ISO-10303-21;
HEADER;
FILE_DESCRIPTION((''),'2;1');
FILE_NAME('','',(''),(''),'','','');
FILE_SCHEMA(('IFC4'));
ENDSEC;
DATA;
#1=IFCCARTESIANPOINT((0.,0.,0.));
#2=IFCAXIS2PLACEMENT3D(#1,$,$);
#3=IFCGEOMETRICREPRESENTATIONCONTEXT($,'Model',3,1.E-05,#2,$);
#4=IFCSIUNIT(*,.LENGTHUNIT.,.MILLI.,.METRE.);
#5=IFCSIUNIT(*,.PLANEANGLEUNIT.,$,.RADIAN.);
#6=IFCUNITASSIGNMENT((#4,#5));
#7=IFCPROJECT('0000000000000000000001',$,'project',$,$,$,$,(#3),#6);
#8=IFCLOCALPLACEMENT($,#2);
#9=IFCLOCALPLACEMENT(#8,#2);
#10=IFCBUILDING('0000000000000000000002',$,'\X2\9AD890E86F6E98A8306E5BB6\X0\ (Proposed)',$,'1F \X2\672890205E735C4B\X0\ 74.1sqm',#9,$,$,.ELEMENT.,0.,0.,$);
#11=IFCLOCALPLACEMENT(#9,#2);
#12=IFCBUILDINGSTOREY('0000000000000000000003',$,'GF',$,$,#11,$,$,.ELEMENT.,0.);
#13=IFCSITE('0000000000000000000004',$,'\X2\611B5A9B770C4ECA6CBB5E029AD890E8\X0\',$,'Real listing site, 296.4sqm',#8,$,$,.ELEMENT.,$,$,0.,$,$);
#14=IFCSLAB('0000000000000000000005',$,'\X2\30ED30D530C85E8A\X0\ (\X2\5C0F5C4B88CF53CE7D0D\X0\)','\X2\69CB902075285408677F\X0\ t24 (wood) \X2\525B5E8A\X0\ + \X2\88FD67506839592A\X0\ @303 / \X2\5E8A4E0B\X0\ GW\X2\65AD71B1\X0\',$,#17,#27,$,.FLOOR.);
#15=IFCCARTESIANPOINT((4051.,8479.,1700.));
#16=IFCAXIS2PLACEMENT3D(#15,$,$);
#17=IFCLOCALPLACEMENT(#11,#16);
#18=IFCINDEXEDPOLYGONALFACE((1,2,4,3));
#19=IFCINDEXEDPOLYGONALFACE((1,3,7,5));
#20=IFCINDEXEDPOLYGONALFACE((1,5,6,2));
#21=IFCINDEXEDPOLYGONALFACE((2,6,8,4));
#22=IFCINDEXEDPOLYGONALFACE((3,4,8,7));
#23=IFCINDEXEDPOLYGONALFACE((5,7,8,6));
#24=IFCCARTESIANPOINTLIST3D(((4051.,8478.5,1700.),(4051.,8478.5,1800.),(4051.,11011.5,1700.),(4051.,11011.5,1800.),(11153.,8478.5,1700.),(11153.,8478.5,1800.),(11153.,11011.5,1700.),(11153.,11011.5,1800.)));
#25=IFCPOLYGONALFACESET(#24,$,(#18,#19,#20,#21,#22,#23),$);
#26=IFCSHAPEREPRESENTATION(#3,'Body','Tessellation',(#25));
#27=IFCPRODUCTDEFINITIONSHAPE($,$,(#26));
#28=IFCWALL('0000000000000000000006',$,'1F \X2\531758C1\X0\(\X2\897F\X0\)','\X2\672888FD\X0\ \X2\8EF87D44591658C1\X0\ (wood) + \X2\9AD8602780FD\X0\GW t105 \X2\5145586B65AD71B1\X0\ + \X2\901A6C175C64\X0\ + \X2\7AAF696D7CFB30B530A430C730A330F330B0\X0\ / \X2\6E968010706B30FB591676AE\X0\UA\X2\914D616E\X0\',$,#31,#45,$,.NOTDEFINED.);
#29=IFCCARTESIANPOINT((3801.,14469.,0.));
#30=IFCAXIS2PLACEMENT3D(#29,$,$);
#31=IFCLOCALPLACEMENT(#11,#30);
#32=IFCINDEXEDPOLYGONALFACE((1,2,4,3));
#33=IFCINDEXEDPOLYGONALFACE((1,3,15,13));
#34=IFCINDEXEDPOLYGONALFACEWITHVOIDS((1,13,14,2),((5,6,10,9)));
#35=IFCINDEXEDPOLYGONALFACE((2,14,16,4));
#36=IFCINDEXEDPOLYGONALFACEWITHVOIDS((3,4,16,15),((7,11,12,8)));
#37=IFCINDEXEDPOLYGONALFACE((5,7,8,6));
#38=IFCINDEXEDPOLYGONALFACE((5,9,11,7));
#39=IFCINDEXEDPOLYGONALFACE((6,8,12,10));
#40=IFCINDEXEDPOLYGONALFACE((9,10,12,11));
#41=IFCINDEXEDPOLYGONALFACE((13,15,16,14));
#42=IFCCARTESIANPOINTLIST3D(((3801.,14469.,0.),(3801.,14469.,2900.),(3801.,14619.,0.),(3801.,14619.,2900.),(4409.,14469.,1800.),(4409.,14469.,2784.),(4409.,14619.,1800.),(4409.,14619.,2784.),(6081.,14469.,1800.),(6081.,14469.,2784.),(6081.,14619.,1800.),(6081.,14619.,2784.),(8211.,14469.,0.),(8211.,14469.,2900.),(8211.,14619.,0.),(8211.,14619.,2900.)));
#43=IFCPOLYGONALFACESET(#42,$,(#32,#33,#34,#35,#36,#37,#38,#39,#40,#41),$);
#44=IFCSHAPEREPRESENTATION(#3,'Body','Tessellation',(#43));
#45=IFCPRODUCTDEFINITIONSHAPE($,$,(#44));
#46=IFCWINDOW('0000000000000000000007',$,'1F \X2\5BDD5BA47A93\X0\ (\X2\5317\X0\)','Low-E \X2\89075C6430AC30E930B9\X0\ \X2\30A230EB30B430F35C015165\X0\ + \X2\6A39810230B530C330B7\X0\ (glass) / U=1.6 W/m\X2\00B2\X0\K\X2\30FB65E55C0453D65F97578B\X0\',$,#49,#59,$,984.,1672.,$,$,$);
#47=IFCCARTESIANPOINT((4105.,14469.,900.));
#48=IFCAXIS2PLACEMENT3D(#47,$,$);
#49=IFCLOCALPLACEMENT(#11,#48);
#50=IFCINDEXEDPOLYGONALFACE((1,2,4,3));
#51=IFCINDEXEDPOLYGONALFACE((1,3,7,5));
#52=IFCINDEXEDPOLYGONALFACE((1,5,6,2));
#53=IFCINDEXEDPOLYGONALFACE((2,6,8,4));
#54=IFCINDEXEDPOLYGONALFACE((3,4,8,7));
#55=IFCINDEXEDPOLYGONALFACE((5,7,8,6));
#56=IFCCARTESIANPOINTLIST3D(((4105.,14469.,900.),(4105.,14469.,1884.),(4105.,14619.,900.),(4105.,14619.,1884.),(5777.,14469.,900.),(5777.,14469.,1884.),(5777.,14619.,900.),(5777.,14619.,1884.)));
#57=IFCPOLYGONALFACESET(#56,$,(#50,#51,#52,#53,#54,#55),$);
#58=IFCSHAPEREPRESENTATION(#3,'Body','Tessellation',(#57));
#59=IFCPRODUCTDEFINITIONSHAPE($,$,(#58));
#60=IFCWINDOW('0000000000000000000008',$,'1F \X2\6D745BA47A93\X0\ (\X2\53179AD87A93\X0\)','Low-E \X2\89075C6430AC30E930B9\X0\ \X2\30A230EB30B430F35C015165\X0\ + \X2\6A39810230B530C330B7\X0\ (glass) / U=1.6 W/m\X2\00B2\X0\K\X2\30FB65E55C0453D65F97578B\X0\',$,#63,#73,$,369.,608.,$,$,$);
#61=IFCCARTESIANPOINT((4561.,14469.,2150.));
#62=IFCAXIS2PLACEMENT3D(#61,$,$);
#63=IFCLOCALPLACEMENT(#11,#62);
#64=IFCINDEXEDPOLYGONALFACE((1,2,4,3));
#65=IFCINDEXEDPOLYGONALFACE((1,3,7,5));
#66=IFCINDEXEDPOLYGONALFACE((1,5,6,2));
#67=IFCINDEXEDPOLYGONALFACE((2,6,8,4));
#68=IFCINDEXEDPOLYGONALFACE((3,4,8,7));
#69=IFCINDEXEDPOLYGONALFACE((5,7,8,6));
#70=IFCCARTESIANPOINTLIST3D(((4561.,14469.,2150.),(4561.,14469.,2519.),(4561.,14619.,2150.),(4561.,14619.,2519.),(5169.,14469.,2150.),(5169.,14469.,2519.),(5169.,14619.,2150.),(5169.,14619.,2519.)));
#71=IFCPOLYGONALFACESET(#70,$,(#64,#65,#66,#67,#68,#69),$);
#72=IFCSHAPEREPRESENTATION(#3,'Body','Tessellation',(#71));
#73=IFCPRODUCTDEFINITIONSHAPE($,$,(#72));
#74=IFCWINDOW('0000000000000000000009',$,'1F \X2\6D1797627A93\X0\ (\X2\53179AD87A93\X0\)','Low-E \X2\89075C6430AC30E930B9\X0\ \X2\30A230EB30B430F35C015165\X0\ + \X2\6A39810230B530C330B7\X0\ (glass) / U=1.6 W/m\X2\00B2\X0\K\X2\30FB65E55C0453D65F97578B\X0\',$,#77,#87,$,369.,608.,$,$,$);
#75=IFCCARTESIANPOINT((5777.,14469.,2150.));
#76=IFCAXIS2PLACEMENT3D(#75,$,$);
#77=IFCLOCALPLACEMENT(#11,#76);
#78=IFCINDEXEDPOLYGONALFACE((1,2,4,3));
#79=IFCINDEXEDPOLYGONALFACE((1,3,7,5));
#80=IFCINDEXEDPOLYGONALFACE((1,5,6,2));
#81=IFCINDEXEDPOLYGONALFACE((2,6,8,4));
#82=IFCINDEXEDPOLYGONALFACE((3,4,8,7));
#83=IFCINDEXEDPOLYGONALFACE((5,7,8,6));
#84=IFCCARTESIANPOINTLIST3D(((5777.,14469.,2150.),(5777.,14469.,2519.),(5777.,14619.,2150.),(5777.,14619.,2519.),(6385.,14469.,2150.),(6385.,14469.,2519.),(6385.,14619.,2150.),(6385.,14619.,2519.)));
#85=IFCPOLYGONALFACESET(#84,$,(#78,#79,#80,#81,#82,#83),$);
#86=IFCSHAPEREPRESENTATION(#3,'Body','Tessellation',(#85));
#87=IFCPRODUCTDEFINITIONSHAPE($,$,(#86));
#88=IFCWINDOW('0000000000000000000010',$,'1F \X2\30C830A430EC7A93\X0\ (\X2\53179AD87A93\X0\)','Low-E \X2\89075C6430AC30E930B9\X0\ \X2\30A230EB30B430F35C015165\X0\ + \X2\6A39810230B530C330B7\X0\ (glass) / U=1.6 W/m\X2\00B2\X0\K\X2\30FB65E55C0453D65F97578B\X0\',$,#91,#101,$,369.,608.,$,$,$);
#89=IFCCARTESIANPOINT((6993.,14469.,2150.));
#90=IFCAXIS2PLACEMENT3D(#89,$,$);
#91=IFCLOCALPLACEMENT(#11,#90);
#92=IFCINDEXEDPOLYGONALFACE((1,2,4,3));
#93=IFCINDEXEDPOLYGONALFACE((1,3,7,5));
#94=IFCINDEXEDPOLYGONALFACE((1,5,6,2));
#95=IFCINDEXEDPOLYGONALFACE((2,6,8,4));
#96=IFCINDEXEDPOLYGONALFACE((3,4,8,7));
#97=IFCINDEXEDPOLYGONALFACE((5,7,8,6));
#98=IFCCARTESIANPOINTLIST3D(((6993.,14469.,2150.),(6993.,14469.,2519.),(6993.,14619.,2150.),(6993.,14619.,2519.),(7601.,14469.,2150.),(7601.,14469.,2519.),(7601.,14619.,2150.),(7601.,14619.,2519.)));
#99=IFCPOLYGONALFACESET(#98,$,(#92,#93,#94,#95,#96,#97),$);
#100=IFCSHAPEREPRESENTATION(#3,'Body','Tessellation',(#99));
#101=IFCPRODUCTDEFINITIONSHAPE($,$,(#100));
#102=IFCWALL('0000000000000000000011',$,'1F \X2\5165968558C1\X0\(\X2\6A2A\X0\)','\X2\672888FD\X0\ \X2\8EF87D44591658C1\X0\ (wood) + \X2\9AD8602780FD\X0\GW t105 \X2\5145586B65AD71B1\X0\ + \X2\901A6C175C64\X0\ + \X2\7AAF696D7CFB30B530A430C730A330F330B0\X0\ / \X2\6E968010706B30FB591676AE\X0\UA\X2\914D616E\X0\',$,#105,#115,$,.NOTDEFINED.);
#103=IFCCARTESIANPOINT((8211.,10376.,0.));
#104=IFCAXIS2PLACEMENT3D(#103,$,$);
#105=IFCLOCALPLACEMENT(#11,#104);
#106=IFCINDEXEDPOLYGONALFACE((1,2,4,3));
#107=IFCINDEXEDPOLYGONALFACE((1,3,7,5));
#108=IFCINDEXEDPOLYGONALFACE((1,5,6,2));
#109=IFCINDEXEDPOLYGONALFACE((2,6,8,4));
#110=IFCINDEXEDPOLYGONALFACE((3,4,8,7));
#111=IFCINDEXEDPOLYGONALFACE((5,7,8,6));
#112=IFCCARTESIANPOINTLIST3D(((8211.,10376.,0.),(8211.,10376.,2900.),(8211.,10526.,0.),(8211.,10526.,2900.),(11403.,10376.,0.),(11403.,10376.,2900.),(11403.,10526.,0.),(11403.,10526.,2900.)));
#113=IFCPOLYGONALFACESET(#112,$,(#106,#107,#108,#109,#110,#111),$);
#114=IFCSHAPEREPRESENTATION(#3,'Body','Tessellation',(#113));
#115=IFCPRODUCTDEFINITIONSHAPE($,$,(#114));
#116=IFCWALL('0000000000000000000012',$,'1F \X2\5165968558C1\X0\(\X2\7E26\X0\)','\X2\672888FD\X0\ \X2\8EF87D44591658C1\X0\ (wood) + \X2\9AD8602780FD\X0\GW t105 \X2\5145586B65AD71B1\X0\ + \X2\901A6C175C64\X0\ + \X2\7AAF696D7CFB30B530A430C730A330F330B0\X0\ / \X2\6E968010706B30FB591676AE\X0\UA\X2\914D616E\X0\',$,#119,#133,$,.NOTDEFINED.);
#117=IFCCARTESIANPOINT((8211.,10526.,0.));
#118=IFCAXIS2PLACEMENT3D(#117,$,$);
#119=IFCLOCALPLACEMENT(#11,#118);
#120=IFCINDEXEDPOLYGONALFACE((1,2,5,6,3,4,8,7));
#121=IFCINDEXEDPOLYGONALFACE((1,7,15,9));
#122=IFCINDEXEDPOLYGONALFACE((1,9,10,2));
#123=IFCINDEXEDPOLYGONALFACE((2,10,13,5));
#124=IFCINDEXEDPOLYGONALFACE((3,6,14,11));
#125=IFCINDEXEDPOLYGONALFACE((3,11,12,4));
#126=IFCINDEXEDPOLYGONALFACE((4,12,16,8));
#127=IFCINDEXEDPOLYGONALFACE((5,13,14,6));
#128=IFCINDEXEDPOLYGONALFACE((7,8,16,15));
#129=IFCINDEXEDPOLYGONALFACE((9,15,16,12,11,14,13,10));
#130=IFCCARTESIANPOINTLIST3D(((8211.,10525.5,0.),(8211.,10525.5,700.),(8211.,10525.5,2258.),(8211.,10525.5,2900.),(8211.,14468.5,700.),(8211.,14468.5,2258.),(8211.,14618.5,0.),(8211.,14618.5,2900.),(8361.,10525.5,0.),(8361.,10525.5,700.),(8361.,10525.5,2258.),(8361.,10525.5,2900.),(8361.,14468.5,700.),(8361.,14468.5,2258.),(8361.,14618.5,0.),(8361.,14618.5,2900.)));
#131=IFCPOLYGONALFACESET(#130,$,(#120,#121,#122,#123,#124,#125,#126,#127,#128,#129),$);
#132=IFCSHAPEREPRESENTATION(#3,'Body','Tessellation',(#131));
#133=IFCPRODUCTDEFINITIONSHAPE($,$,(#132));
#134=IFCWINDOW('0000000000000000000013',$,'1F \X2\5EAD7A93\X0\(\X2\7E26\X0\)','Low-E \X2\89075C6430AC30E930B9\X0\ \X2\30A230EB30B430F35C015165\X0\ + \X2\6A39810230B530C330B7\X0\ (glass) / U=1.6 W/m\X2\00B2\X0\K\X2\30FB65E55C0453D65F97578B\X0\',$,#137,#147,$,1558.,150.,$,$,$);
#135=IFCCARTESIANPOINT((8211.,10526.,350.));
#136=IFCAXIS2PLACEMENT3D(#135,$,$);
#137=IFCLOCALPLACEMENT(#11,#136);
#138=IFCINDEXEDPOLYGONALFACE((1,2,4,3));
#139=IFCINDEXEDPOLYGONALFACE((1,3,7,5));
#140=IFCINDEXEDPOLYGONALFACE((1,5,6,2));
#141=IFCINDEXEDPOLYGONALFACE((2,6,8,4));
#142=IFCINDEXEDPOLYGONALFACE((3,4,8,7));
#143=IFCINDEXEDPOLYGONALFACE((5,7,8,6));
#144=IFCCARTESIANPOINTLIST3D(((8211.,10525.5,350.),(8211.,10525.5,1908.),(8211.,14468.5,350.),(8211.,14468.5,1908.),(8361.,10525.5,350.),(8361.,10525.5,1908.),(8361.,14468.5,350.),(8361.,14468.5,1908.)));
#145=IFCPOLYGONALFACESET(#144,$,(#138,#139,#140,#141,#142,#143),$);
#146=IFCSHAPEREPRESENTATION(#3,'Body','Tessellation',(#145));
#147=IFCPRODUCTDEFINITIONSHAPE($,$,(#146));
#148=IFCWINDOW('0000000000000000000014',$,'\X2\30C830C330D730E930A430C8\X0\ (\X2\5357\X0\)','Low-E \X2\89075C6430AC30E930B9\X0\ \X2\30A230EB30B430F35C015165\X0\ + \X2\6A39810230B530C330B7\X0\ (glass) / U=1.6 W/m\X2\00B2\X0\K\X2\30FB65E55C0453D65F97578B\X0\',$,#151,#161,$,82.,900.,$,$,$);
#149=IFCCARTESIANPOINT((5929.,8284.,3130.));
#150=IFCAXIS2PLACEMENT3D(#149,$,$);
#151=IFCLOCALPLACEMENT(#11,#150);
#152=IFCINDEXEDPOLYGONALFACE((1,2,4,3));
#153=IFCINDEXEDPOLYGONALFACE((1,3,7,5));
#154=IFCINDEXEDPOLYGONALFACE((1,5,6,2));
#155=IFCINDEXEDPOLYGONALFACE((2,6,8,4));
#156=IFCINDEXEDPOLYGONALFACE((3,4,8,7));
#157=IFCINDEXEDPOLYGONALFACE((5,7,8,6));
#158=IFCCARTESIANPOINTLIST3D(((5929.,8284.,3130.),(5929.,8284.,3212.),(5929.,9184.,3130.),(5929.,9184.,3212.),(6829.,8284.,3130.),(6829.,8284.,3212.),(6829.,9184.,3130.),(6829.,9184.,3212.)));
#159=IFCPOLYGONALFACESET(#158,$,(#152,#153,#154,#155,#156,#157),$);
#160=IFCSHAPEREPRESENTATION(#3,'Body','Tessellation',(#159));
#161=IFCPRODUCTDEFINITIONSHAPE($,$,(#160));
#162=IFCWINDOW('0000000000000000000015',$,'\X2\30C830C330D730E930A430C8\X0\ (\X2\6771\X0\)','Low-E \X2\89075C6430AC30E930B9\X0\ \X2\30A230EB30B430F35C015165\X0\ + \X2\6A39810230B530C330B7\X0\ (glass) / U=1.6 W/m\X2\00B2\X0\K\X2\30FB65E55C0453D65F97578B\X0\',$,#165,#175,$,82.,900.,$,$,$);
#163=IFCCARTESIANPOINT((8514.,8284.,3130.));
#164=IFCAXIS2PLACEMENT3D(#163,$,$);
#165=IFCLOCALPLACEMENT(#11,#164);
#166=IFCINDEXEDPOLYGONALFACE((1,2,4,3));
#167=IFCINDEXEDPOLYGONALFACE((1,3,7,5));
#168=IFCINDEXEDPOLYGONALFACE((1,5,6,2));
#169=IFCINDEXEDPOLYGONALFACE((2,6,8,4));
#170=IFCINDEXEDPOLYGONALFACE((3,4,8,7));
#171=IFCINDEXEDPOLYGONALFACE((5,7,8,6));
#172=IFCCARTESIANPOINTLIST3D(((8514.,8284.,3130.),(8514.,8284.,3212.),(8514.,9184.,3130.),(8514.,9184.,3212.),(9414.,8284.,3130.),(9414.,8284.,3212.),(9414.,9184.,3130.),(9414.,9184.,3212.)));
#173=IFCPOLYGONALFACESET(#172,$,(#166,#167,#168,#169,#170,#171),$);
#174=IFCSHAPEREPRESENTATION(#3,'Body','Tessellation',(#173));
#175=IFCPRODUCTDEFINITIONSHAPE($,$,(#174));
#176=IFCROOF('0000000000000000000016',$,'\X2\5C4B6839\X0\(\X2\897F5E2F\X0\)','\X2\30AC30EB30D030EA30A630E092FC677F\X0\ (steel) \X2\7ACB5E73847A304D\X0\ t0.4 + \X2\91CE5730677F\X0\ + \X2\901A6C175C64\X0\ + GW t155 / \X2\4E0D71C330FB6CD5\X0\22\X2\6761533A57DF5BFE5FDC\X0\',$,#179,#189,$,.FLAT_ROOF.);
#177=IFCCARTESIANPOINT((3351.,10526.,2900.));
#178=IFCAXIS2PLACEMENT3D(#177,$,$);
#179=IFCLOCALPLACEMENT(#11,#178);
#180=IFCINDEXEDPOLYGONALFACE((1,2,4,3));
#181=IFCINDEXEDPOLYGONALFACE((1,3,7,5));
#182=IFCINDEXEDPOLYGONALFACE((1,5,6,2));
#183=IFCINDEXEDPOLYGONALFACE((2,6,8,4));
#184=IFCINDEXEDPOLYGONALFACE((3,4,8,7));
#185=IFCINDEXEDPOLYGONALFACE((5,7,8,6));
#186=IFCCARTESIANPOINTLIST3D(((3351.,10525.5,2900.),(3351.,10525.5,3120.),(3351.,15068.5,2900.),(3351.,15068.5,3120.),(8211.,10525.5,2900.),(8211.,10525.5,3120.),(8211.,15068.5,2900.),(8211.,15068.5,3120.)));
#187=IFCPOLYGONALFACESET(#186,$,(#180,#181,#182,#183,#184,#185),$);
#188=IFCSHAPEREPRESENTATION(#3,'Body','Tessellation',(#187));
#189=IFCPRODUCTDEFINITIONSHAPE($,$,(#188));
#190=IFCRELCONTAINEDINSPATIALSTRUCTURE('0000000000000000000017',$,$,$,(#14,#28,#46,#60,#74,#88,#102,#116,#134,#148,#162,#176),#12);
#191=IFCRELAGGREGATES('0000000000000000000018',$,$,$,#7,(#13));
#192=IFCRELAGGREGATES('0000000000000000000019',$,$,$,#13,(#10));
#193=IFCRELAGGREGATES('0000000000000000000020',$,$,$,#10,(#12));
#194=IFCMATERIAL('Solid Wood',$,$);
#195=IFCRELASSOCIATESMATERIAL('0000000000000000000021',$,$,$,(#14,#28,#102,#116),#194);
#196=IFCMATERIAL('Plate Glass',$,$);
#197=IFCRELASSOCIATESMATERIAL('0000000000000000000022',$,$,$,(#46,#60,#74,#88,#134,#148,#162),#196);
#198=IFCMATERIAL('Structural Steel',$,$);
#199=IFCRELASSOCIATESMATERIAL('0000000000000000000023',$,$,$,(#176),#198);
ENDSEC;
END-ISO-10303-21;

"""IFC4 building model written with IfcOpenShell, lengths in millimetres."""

from ifc_helpers import new_model, si_unit, frame, frame_2d, origin, place, context, project, spatial, rectangle, extrude, material, element, fill, save


model = new_model("IFC4")

# Units and contexts
model_context = context("Model", 3, precision=1e-05, world=origin())
ifc_project = project(units=[si_unit("LENGTHUNIT", "METRE", prefix="MILLI"), si_unit("PLANEANGLEUNIT", "RADIAN")], contexts=[model_context])

# Site, building, storey
site_placement = place(None, origin())
site = spatial("IfcSite", under=ifc_project, at=site_placement, Name="愛媛県今治市高部", ObjectType="Real listing site, 296.4sqm", CompositionType="ELEMENT", RefElevation=0.0)
building_placement = place(site_placement, origin())
building = spatial("IfcBuilding", under=site, at=building_placement, Name="高部潮風の家 (Proposed)", ObjectType="1F 木造平屋 74.1sqm", CompositionType="ELEMENT", ElevationOfRefHeight=0.0, ElevationOfTerrain=0.0)
storey_placement = place(building_placement, origin())
storey = spatial("IfcBuildingStorey", under=building, at=storey_placement, Name="GF", CompositionType="ELEMENT", Elevation=0.0)

# Slab
ifc_material_1 = material(Name="Solid Wood")
slab_1_placement = place(storey_placement, frame((4051.0, 8479.0, 1700.0)))
element("IfcSlab", 1, at=slab_1_placement, inside=storey, material=ifc_material_1, Name="ロフト床 (小屋裏収納)", Description="構造用合板 t24 (wood) 剛床 + 製材根太 @303 / 床下 GW断熱", PredefinedType="FLOOR", context=model_context, shape_type="SweptSolid", body=[
    extrude(rectangle(XDim=7102.0, YDim=2533.0, at=frame_2d((3551.0, 1266.0))), frame((4051.0, 8479.0, 1700.0)), (0.0, 0.0, 1.0), 100.0),
])

# Wall, openings, windows
wall_1_placement = place(storey_placement, frame((3801.0, 14469.0, 0.0)))
wall_1 = element("IfcWall", 2, at=wall_1_placement, inside=storey, material=ifc_material_1, Name="1F 北壁(西)", Description="木製 軸組外壁 (wood) + 高性能GW t105 充填断熱 + 通気層 + 窯業系サイディング / 準耐火・外皮UA配慮", PredefinedType="NOTDEFINED", context=model_context, shape_type="SweptSolid", body=[
    extrude(rectangle(XDim=4410.0, YDim=150.0, at=frame_2d((2205.0, 75.0))), frame((3801.0, 14469.0, 0.0)), (0.0, 0.0, 1.0), 2900.0),
])
opening_1_placement = place(storey_placement, frame((4105.0, 14469.0, 900.0)))
opening_1 = element("IfcOpeningElement", 3, at=opening_1_placement, cuts=wall_1, PredefinedType="NOTDEFINED", context=model_context, shape_type="SweptSolid", body=[
    extrude(rectangle(XDim=1672.0, YDim=150.0, at=frame_2d((836.0, 75.0))), frame((4105.0, 14469.0, 900.0)), (0.0, 0.0, 1.0), 984.0),
])
opening_2_placement = place(storey_placement, frame((4561.0, 14469.0, 2150.0)))
opening_2 = element("IfcOpeningElement", 4, at=opening_2_placement, cuts=wall_1, PredefinedType="NOTDEFINED", context=model_context, shape_type="SweptSolid", body=[
    extrude(rectangle(XDim=608.0, YDim=150.0, at=frame_2d((304.0, 75.0))), frame((4561.0, 14469.0, 2150.0)), (0.0, 0.0, 1.0), 369.0),
])
opening_3_placement = place(storey_placement, frame((5777.0, 14469.0, 2150.0)))
opening_3 = element("IfcOpeningElement", 5, at=opening_3_placement, cuts=wall_1, PredefinedType="NOTDEFINED", context=model_context, shape_type="SweptSolid", body=[
    extrude(rectangle(XDim=608.0, YDim=150.0, at=frame_2d((304.0, 75.0))), frame((5777.0, 14469.0, 2150.0)), (0.0, 0.0, 1.0), 369.0),
])
opening_4_placement = place(storey_placement, frame((6993.0, 14469.0, 2150.0)))
opening_4 = element("IfcOpeningElement", 6, at=opening_4_placement, cuts=wall_1, PredefinedType="NOTDEFINED", context=model_context, shape_type="SweptSolid", body=[
    extrude(rectangle(XDim=608.0, YDim=150.0, at=frame_2d((304.0, 75.0))), frame((6993.0, 14469.0, 2150.0)), (0.0, 0.0, 1.0), 369.0),
])
ifc_material_2 = material(Name="Plate Glass")
window_1_placement = place(storey_placement, frame((4105.0, 14469.0, 900.0)))
window_1 = element("IfcWindow", 7, at=window_1_placement, inside=storey, material=ifc_material_2, Name="1F 寝室窓 (北)", Description="Low-E 複層ガラス アルゴン封入 + 樹脂サッシ (glass) / U=1.6 W/m²K・日射取得型", OverallHeight=984.0, OverallWidth=1672.0, context=model_context, shape_type="SweptSolid", body=[
    extrude(rectangle(XDim=1672.0, YDim=150.0, at=frame_2d((836.0, 75.0))), frame((4105.0, 14469.0, 900.0)), (0.0, 0.0, 1.0), 984.0),
])
fill(opening_1, window_1)
window_2_placement = place(storey_placement, frame((4561.0, 14469.0, 2150.0)))
window_2 = element("IfcWindow", 8, at=window_2_placement, inside=storey, material=ifc_material_2, Name="1F 浴室窓 (北高窓)", Description="Low-E 複層ガラス アルゴン封入 + 樹脂サッシ (glass) / U=1.6 W/m²K・日射取得型", OverallHeight=369.0, OverallWidth=608.0, context=model_context, shape_type="SweptSolid", body=[
    extrude(rectangle(XDim=608.0, YDim=150.0, at=frame_2d((304.0, 75.0))), frame((4561.0, 14469.0, 2150.0)), (0.0, 0.0, 1.0), 369.0),
])
fill(opening_2, window_2)
window_3_placement = place(storey_placement, frame((5777.0, 14469.0, 2150.0)))
window_3 = element("IfcWindow", 9, at=window_3_placement, inside=storey, material=ifc_material_2, Name="1F 洗面窓 (北高窓)", Description="Low-E 複層ガラス アルゴン封入 + 樹脂サッシ (glass) / U=1.6 W/m²K・日射取得型", OverallHeight=369.0, OverallWidth=608.0, context=model_context, shape_type="SweptSolid", body=[
    extrude(rectangle(XDim=608.0, YDim=150.0, at=frame_2d((304.0, 75.0))), frame((5777.0, 14469.0, 2150.0)), (0.0, 0.0, 1.0), 369.0),
])
fill(opening_3, window_3)
window_4_placement = place(storey_placement, frame((6993.0, 14469.0, 2150.0)))
window_4 = element("IfcWindow", 10, at=window_4_placement, inside=storey, material=ifc_material_2, Name="1F トイレ窓 (北高窓)", Description="Low-E 複層ガラス アルゴン封入 + 樹脂サッシ (glass) / U=1.6 W/m²K・日射取得型", OverallHeight=369.0, OverallWidth=608.0, context=model_context, shape_type="SweptSolid", body=[
    extrude(rectangle(XDim=608.0, YDim=150.0, at=frame_2d((304.0, 75.0))), frame((6993.0, 14469.0, 2150.0)), (0.0, 0.0, 1.0), 369.0),
])
fill(opening_4, window_4)

# Wall
wall_2_placement = place(storey_placement, frame((8211.0, 10376.0, 0.0)))
element("IfcWall", 11, at=wall_2_placement, inside=storey, material=ifc_material_1, Name="1F 入隅壁(横)", Description="木製 軸組外壁 (wood) + 高性能GW t105 充填断熱 + 通気層 + 窯業系サイディング / 準耐火・外皮UA配慮", PredefinedType="NOTDEFINED", context=model_context, shape_type="SweptSolid", body=[
    extrude(rectangle(XDim=3192.0, YDim=150.0, at=frame_2d((1596.0, 75.0))), frame((8211.0, 10376.0, 0.0)), (0.0, 0.0, 1.0), 2900.0),
])

# Wall, opening, window
wall_3_placement = place(storey_placement, frame((8211.0, 10526.0, 0.0)))
wall_3 = element("IfcWall", 12, at=wall_3_placement, inside=storey, material=ifc_material_1, Name="1F 入隅壁(縦)", Description="木製 軸組外壁 (wood) + 高性能GW t105 充填断熱 + 通気層 + 窯業系サイディング / 準耐火・外皮UA配慮", PredefinedType="NOTDEFINED", context=model_context, shape_type="SweptSolid", body=[
    extrude(rectangle(XDim=150.0, YDim=4093.0, at=frame_2d((75.0, 2046.0))), frame((8211.0, 10526.0, 0.0)), (0.0, 0.0, 1.0), 2900.0),
])
opening_5_placement = place(storey_placement, frame((8211.0, 10526.0, 350.0)))
opening_5 = element("IfcOpeningElement", 13, at=opening_5_placement, cuts=wall_3, PredefinedType="NOTDEFINED", context=model_context, shape_type="SweptSolid", body=[
    extrude(rectangle(XDim=150.0, YDim=3943.0, at=frame_2d((75.0, 1971.0))), frame((8211.0, 10526.0, 350.0)), (0.0, 0.0, 1.0), 1558.0),
])
window_5_placement = place(storey_placement, frame((8211.0, 10526.0, 350.0)))
window_5 = element("IfcWindow", 14, at=window_5_placement, inside=storey, material=ifc_material_2, Name="1F 庭窓(縦)", Description="Low-E 複層ガラス アルゴン封入 + 樹脂サッシ (glass) / U=1.6 W/m²K・日射取得型", OverallHeight=1558.0, OverallWidth=150.0, context=model_context, shape_type="SweptSolid", body=[
    extrude(rectangle(XDim=150.0, YDim=3943.0, at=frame_2d((75.0, 1971.0))), frame((8211.0, 10526.0, 350.0)), (0.0, 0.0, 1.0), 1558.0),
])
fill(opening_5, window_5)

# Windows
window_6_placement = place(storey_placement, frame((5929.0, 8284.0, 3130.0)))
element("IfcWindow", 15, at=window_6_placement, inside=storey, material=ifc_material_2, Name="トップライト (南)", Description="Low-E 複層ガラス アルゴン封入 + 樹脂サッシ (glass) / U=1.6 W/m²K・日射取得型", OverallHeight=82.0, OverallWidth=900.0, context=model_context, shape_type="SweptSolid", body=[
    extrude(rectangle(XDim=900.0, YDim=900.0, at=frame_2d((450.0, 450.0))), frame((5929.0, 8284.0, 3130.0)), (0.0, 0.0, 1.0), 82.0),
])
window_7_placement = place(storey_placement, frame((8514.0, 8284.0, 3130.0)))
element("IfcWindow", 16, at=window_7_placement, inside=storey, material=ifc_material_2, Name="トップライト (東)", Description="Low-E 複層ガラス アルゴン封入 + 樹脂サッシ (glass) / U=1.6 W/m²K・日射取得型", OverallHeight=82.0, OverallWidth=900.0, context=model_context, shape_type="SweptSolid", body=[
    extrude(rectangle(XDim=900.0, YDim=900.0, at=frame_2d((450.0, 450.0))), frame((8514.0, 8284.0, 3130.0)), (0.0, 0.0, 1.0), 82.0),
])

# Roof
ifc_material_3 = material(Name="Structural Steel")
roof_placement = place(storey_placement, frame((3351.0, 10526.0, 2900.0)))
element("IfcRoof", 17, at=roof_placement, inside=storey, material=ifc_material_3, Name="屋根(西帯)", Description="ガルバリウム鋼板 (steel) 立平葺き t0.4 + 野地板 + 通気層 + GW t155 / 不燃・法22条区域対応", PredefinedType="FLAT_ROOF", context=model_context, shape_type="SweptSolid", body=[
    extrude(rectangle(XDim=4860.0, YDim=4543.0, at=frame_2d((2430.0, 2271.0))), frame((3351.0, 10526.0, 2900.0)), (0.0, 0.0, 1.0), 220.0),
])

save(model, "model.ifc")
